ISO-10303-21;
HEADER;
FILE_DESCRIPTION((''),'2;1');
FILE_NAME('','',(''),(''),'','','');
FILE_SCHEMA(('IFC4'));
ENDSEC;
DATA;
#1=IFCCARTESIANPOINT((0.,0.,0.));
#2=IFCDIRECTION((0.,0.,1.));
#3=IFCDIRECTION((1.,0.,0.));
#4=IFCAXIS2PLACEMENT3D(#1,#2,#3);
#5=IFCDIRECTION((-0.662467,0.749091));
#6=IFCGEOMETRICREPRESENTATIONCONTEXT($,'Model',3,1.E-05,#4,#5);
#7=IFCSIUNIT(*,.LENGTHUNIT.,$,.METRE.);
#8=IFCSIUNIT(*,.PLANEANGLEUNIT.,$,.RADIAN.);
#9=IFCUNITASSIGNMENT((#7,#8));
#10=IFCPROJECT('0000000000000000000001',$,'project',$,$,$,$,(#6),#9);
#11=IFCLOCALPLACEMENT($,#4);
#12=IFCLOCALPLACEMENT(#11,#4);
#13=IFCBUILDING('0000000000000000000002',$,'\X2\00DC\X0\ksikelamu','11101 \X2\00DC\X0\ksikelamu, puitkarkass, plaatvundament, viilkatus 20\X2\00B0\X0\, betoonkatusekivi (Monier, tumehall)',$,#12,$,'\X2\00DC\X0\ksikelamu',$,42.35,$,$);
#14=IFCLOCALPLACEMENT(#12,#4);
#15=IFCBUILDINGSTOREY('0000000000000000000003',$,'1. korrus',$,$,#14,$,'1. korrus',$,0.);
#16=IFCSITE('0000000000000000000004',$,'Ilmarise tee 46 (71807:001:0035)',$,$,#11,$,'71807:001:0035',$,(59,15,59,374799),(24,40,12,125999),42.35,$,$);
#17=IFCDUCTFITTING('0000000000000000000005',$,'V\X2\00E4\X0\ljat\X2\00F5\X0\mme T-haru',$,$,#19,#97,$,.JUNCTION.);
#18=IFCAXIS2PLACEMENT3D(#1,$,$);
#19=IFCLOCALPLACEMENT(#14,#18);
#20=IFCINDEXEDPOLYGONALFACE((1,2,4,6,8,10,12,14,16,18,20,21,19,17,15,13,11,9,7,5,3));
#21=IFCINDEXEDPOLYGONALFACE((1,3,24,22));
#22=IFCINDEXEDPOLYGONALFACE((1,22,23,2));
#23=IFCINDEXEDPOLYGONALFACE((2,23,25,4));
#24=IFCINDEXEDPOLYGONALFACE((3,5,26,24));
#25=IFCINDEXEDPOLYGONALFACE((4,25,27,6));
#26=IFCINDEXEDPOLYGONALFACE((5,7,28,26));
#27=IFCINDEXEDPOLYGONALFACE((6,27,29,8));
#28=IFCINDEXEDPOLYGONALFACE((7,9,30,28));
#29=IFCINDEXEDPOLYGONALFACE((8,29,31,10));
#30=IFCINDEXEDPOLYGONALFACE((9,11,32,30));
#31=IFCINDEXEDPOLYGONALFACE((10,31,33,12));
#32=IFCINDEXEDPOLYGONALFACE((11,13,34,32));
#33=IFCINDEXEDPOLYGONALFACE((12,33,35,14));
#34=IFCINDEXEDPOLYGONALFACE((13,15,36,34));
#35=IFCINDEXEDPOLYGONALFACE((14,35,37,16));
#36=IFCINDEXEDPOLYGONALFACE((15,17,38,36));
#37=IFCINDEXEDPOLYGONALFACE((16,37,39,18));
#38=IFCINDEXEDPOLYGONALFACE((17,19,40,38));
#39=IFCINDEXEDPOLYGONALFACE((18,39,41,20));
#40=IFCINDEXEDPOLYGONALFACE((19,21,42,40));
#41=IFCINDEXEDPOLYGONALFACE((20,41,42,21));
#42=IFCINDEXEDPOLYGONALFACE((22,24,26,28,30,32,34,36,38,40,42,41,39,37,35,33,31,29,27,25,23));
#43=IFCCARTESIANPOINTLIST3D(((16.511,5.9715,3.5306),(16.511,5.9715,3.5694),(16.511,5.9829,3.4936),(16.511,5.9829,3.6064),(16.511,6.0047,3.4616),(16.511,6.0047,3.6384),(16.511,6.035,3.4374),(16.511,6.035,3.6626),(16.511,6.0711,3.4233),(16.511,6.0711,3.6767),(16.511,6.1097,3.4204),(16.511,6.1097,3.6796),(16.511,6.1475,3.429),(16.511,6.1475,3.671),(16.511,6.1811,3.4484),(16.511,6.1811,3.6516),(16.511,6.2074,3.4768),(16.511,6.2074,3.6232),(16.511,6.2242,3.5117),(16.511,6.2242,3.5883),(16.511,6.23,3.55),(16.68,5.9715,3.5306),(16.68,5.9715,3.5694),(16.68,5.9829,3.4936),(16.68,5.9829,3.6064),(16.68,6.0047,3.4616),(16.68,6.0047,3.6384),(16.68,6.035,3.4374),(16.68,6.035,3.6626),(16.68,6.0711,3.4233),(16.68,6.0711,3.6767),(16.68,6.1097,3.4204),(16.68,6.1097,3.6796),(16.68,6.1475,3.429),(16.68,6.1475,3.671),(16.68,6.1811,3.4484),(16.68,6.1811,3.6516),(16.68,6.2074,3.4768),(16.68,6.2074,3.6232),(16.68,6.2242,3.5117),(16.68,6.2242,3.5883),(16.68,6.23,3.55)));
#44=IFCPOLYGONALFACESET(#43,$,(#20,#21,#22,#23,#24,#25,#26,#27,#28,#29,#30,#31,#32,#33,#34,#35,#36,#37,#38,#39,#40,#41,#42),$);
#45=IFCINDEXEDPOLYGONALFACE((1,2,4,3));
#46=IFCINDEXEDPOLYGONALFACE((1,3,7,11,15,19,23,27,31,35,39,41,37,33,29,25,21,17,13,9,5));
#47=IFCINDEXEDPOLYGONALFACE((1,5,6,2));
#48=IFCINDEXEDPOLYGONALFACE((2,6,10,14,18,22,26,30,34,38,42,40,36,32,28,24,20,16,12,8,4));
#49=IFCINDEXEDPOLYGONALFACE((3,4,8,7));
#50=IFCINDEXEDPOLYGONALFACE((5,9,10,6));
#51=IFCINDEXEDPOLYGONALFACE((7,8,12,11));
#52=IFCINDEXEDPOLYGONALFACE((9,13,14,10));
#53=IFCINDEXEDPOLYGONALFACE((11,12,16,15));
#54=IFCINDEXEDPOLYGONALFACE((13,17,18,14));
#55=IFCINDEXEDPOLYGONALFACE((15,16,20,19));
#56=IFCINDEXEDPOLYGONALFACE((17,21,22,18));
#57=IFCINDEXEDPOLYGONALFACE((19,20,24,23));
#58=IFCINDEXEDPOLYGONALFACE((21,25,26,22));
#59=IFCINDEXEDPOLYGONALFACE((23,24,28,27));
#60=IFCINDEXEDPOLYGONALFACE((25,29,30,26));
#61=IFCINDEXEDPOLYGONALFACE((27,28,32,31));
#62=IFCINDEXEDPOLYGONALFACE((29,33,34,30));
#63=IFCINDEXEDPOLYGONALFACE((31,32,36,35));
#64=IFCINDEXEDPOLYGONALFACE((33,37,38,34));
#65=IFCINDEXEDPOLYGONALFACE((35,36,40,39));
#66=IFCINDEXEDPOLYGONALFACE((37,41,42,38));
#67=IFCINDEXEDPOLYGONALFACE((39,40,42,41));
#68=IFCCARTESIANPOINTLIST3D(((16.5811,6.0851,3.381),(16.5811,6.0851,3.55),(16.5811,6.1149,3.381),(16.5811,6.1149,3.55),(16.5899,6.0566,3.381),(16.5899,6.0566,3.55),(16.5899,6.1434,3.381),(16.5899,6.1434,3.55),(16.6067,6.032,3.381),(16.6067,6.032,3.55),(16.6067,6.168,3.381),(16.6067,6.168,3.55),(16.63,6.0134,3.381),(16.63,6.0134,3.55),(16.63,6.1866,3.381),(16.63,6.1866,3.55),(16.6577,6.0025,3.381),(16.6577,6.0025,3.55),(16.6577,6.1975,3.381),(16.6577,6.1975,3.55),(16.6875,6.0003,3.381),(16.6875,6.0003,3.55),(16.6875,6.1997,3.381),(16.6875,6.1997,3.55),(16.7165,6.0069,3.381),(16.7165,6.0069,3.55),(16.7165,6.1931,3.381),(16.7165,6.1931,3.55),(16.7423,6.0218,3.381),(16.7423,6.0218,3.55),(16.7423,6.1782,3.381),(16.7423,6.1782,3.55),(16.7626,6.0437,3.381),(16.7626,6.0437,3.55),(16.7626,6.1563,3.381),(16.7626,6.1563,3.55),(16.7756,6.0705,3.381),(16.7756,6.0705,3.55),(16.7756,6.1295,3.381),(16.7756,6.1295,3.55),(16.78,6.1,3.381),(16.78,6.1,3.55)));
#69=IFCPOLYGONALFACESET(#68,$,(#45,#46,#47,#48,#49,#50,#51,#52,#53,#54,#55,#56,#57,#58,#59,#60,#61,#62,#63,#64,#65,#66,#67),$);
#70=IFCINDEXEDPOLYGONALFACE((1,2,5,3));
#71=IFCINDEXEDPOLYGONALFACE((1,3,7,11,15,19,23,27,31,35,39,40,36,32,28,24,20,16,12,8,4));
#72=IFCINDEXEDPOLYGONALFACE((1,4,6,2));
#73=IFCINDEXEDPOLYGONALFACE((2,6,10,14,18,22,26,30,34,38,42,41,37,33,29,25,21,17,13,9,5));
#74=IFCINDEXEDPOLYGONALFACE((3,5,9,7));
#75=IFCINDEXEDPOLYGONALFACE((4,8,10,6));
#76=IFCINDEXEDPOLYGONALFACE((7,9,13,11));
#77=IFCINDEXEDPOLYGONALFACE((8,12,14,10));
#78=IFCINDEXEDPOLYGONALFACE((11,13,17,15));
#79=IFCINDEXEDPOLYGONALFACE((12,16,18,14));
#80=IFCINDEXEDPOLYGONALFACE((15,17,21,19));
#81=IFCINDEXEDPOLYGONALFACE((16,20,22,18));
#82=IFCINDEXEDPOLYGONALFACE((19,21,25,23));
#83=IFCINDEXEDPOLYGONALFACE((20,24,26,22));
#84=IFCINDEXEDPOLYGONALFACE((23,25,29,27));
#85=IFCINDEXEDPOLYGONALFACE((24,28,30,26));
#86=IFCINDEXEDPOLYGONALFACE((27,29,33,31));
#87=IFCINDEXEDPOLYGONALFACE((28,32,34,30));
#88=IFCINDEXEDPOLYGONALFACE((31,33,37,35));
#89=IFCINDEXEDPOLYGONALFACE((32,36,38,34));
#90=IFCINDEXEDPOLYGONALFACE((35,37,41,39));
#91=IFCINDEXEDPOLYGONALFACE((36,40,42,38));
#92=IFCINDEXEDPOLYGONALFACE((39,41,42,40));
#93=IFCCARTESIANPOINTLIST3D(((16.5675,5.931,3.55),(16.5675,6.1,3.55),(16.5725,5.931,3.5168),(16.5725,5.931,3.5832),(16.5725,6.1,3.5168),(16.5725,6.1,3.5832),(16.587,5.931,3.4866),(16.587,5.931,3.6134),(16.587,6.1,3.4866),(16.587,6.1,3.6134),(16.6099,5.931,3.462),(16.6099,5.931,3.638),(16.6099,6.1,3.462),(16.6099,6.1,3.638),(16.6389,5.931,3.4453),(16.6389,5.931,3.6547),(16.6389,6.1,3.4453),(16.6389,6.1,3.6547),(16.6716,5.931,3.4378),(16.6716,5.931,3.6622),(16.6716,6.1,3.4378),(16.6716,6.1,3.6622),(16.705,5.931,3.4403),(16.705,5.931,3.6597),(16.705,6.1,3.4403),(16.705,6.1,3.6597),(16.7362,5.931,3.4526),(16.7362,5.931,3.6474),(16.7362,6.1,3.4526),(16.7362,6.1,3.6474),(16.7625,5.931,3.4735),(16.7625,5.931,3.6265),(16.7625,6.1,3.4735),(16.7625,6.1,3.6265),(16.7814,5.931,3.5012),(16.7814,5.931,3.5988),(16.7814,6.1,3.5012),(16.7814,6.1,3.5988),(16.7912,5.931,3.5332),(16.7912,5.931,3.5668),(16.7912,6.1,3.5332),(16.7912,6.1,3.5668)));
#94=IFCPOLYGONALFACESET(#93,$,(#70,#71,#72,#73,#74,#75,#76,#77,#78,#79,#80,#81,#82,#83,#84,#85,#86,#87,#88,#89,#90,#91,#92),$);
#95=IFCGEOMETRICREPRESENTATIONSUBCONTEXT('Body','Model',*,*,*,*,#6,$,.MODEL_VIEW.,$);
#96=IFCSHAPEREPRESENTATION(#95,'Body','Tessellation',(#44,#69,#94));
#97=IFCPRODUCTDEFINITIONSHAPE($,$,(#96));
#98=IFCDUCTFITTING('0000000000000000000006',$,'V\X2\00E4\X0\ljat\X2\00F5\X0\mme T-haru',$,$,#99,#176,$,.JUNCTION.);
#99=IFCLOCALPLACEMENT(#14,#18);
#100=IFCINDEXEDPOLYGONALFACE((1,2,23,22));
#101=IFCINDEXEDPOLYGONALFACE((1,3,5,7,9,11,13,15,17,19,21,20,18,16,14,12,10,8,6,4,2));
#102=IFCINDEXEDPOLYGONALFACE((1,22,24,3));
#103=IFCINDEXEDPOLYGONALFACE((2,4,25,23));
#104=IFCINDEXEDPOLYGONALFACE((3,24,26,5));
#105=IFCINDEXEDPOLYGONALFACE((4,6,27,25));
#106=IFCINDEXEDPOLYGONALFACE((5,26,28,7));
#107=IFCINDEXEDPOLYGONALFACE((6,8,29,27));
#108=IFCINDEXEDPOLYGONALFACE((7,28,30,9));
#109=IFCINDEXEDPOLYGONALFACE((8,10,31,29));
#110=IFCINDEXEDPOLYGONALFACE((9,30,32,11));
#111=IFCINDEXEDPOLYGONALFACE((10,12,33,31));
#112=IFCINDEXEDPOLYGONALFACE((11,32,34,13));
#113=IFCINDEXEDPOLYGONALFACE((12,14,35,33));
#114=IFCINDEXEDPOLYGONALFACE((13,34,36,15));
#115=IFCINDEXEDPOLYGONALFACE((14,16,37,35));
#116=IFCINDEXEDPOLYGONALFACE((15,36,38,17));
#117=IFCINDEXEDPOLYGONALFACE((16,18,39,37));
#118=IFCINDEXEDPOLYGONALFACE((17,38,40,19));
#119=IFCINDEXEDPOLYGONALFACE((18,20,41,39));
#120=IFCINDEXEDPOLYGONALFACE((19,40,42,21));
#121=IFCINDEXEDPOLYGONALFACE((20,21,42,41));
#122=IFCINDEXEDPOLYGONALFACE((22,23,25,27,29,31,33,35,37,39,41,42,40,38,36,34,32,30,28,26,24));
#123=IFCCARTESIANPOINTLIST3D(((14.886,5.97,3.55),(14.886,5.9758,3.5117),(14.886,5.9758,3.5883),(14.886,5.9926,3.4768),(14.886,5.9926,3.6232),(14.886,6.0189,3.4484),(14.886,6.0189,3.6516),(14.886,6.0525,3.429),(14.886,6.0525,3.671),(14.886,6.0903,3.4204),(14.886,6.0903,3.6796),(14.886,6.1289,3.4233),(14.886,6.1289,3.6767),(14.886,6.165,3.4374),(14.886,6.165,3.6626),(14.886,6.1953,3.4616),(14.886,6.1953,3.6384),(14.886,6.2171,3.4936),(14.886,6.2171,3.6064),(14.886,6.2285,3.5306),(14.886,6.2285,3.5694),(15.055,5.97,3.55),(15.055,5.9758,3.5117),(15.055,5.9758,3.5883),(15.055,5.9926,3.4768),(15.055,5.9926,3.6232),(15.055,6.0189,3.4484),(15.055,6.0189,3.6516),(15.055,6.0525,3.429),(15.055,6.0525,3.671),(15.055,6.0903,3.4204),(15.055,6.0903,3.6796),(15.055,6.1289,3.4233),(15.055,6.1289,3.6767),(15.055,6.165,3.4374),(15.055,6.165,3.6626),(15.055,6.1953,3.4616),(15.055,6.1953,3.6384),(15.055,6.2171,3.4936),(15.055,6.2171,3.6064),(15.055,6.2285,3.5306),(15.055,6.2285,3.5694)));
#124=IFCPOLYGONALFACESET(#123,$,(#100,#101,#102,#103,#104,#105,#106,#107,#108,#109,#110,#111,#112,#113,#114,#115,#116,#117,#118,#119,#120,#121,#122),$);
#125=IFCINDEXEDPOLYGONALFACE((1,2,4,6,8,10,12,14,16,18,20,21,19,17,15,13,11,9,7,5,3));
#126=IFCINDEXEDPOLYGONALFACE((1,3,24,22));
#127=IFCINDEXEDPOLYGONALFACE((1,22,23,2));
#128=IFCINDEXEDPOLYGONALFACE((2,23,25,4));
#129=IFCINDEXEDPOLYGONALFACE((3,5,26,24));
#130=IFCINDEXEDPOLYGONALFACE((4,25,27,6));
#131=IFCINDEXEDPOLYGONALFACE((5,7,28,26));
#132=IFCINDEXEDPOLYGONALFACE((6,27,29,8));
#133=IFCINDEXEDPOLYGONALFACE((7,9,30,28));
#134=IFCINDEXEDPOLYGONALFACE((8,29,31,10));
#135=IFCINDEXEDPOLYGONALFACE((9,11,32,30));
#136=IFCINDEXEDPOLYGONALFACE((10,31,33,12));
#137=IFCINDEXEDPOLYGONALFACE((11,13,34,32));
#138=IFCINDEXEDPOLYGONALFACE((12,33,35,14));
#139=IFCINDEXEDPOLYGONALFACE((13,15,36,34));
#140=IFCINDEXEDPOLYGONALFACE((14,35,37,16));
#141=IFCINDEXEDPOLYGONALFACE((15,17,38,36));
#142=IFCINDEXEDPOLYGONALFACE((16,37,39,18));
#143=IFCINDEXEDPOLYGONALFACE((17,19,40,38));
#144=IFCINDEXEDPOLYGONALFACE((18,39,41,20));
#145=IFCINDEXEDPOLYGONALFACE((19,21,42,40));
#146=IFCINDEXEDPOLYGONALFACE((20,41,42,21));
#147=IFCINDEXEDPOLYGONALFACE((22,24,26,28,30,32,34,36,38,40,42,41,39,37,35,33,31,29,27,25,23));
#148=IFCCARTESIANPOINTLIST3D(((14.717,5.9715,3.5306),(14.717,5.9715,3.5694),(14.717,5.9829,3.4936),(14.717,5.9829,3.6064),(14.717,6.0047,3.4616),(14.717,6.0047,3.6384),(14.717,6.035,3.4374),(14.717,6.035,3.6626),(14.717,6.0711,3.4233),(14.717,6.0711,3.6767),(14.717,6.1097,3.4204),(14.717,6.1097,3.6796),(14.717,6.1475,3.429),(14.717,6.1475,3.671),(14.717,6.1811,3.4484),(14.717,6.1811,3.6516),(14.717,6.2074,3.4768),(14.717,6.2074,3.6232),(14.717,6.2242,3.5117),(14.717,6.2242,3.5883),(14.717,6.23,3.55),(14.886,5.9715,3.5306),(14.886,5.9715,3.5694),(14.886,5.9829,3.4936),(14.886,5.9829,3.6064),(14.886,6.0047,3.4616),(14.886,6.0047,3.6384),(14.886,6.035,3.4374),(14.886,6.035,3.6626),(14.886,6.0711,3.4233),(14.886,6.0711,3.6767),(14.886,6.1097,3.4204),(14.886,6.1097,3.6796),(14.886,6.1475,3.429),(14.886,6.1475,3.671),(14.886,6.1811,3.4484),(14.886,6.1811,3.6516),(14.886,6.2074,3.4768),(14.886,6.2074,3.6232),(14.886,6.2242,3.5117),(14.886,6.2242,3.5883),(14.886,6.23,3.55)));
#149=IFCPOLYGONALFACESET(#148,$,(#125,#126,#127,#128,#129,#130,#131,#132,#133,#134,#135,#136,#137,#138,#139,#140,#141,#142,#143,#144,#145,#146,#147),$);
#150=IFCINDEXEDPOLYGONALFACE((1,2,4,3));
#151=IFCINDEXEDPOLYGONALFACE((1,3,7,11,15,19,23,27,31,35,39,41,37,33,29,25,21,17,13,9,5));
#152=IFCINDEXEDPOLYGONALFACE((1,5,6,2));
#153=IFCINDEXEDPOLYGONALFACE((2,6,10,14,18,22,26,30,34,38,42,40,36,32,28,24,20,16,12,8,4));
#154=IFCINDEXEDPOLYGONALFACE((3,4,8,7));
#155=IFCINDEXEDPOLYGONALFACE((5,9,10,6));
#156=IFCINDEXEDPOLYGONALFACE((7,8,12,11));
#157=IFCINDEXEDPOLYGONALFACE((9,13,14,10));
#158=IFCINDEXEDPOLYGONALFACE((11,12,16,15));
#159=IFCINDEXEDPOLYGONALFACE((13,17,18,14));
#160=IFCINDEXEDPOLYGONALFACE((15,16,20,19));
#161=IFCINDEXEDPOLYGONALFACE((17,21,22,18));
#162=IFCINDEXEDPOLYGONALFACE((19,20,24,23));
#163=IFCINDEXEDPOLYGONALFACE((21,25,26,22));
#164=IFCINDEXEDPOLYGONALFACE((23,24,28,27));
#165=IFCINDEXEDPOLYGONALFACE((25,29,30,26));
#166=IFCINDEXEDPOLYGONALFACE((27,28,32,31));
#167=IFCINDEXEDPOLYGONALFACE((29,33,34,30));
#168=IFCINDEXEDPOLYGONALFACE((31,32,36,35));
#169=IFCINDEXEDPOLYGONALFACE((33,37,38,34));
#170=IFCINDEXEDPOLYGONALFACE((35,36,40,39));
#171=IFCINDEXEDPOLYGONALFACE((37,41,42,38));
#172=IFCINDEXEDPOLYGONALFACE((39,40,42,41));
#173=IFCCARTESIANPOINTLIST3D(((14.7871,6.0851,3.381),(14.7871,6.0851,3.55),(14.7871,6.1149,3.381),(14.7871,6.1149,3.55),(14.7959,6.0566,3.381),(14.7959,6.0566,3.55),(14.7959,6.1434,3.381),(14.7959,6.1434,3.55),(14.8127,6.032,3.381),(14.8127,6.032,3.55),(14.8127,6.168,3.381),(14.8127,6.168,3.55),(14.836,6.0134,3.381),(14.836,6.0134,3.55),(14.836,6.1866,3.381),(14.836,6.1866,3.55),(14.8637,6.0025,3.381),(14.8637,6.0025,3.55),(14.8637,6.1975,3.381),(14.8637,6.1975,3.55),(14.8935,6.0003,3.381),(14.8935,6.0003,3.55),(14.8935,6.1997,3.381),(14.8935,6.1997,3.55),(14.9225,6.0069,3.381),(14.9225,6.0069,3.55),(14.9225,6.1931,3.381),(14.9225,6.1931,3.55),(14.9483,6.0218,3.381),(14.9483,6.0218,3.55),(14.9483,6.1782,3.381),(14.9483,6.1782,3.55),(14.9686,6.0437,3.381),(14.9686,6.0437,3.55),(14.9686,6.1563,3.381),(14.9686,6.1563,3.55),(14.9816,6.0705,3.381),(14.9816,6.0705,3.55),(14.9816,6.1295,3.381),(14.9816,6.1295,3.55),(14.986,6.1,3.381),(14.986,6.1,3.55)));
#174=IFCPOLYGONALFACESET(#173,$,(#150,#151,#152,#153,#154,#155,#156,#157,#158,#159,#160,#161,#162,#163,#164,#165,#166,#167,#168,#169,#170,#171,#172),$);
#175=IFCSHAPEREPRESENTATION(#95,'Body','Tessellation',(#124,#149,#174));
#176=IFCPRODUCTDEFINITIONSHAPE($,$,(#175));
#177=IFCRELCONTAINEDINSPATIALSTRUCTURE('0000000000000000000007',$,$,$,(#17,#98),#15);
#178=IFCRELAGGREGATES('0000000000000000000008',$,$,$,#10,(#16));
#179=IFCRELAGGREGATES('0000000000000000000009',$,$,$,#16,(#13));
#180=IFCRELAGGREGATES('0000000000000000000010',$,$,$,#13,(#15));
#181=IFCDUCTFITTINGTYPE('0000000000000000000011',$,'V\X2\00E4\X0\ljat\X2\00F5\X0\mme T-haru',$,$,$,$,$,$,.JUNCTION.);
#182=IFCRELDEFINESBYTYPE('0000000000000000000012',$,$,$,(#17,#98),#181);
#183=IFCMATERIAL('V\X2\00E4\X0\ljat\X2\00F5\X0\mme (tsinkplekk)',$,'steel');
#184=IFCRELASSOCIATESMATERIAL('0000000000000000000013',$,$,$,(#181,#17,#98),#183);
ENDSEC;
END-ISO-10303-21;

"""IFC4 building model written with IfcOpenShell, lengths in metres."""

from ifc_helpers import new_model, si_unit, direction, frame, origin_with_axes, place, context, subcontext, project, spatial, circle, extrude, material, type_object, element, save


model = new_model("IFC4")

# Units and contexts
model_context = context("Model", 3, precision=1e-05, world=origin_with_axes(), true_north=direction((-0.662467, 0.749091)))
body_context = subcontext(model_context, "Body", "Model", "MODEL_VIEW")
ifc_project = project(units=[si_unit("LENGTHUNIT", "METRE"), si_unit("PLANEANGLEUNIT", "RADIAN")], contexts=[model_context])

# Site, building, storey
site_placement = place(None, origin_with_axes())
site = spatial("IfcSite", under=ifc_project, at=site_placement, Name="Ilmarise tee 46 (71807:001:0035)", LongName="71807:001:0035", RefLatitude=(59, 15, 59, 374799), RefLongitude=(24, 40, 12, 125999), RefElevation=42.35)
building_placement = place(site_placement, origin_with_axes())
building = spatial("IfcBuilding", under=site, at=building_placement, Name="Üksikelamu", Description="11101 Üksikelamu, puitkarkass, plaatvundament, viilkatus 20°, betoonkatusekivi (Monier, tumehall)", LongName="Üksikelamu", ElevationOfRefHeight=42.35)
storey_placement = place(building_placement, origin_with_axes())
storey = spatial("IfcBuildingStorey", under=building, at=storey_placement, Name="1. korrus", LongName="1. korrus", Elevation=0.0)

# Duct fittings
ifc_material_1 = material(Name="Väljatõmme (tsinkplekk)", Category="steel")
duct_fitting_type_1 = type_object("IfcDuctFittingType", Name="Väljatõmme T-haru", PredefinedType="JUNCTION", material=ifc_material_1)
duct_fitting_1_placement = place(storey_placement, frame((16.68, 6.1, 3.55), z_axis=(0.0, 0.0, 1.0), x_axis=(1.0, 0.0, 0.0)))
element("IfcDuctFitting", 1, at=duct_fitting_1_placement, inside=storey, type_object=duct_fitting_type_1, material=ifc_material_1, Name="Väljatõmme T-haru", PredefinedType="JUNCTION", context=body_context, shape_type="SweptSolid", body=[
    extrude(circle(Radius=0.13), frame((0.0, 0.0, 0.0), z_axis=(-1.0, 0.0, 0.0), x_axis=(0.0, 1.0, 0.0)), (0.0, 0.0, 1.0), 0.169),
    extrude(circle(Radius=0.1), frame((0.0, 0.0, 0.0), z_axis=(0.0, 0.0, -1.0), x_axis=(1.0, 0.0, 0.0)), (0.0, 0.0, 1.0), 0.169),
    extrude(circle(Radius=0.1125), frame((0.0, 0.0, 0.0), z_axis=(0.0, -1.0, 0.0), x_axis=(-1.0, 0.0, 0.0)), (0.0, 0.0, 1.0), 0.169),
])
duct_fitting_2_placement = place(storey_placement, frame((14.886, 6.1, 3.55), z_axis=(0.0, 0.0, 1.0), x_axis=(1.0, 0.0, 0.0)))
element("IfcDuctFitting", 2, at=duct_fitting_2_placement, inside=storey, type_object=duct_fitting_type_1, material=ifc_material_1, Name="Väljatõmme T-haru", PredefinedType="JUNCTION", context=body_context, shape_type="SweptSolid", body=[
    extrude(circle(Radius=0.13), frame((0.0, 0.0, 0.0), z_axis=(1.0, 0.0, 0.0), x_axis=(0.0, -1.0, 0.0)), (0.0, 0.0, 1.0), 0.169),
    extrude(circle(Radius=0.13), frame((0.0, 0.0, 0.0), z_axis=(-1.0, 0.0, 0.0), x_axis=(0.0, 1.0, 0.0)), (0.0, 0.0, 1.0), 0.169),
    extrude(circle(Radius=0.1), frame((0.0, 0.0, 0.0), z_axis=(0.0, 0.0, -1.0), x_axis=(1.0, 0.0, 0.0)), (0.0, 0.0, 1.0), 0.169),
])

save(model, "model.ifc")
